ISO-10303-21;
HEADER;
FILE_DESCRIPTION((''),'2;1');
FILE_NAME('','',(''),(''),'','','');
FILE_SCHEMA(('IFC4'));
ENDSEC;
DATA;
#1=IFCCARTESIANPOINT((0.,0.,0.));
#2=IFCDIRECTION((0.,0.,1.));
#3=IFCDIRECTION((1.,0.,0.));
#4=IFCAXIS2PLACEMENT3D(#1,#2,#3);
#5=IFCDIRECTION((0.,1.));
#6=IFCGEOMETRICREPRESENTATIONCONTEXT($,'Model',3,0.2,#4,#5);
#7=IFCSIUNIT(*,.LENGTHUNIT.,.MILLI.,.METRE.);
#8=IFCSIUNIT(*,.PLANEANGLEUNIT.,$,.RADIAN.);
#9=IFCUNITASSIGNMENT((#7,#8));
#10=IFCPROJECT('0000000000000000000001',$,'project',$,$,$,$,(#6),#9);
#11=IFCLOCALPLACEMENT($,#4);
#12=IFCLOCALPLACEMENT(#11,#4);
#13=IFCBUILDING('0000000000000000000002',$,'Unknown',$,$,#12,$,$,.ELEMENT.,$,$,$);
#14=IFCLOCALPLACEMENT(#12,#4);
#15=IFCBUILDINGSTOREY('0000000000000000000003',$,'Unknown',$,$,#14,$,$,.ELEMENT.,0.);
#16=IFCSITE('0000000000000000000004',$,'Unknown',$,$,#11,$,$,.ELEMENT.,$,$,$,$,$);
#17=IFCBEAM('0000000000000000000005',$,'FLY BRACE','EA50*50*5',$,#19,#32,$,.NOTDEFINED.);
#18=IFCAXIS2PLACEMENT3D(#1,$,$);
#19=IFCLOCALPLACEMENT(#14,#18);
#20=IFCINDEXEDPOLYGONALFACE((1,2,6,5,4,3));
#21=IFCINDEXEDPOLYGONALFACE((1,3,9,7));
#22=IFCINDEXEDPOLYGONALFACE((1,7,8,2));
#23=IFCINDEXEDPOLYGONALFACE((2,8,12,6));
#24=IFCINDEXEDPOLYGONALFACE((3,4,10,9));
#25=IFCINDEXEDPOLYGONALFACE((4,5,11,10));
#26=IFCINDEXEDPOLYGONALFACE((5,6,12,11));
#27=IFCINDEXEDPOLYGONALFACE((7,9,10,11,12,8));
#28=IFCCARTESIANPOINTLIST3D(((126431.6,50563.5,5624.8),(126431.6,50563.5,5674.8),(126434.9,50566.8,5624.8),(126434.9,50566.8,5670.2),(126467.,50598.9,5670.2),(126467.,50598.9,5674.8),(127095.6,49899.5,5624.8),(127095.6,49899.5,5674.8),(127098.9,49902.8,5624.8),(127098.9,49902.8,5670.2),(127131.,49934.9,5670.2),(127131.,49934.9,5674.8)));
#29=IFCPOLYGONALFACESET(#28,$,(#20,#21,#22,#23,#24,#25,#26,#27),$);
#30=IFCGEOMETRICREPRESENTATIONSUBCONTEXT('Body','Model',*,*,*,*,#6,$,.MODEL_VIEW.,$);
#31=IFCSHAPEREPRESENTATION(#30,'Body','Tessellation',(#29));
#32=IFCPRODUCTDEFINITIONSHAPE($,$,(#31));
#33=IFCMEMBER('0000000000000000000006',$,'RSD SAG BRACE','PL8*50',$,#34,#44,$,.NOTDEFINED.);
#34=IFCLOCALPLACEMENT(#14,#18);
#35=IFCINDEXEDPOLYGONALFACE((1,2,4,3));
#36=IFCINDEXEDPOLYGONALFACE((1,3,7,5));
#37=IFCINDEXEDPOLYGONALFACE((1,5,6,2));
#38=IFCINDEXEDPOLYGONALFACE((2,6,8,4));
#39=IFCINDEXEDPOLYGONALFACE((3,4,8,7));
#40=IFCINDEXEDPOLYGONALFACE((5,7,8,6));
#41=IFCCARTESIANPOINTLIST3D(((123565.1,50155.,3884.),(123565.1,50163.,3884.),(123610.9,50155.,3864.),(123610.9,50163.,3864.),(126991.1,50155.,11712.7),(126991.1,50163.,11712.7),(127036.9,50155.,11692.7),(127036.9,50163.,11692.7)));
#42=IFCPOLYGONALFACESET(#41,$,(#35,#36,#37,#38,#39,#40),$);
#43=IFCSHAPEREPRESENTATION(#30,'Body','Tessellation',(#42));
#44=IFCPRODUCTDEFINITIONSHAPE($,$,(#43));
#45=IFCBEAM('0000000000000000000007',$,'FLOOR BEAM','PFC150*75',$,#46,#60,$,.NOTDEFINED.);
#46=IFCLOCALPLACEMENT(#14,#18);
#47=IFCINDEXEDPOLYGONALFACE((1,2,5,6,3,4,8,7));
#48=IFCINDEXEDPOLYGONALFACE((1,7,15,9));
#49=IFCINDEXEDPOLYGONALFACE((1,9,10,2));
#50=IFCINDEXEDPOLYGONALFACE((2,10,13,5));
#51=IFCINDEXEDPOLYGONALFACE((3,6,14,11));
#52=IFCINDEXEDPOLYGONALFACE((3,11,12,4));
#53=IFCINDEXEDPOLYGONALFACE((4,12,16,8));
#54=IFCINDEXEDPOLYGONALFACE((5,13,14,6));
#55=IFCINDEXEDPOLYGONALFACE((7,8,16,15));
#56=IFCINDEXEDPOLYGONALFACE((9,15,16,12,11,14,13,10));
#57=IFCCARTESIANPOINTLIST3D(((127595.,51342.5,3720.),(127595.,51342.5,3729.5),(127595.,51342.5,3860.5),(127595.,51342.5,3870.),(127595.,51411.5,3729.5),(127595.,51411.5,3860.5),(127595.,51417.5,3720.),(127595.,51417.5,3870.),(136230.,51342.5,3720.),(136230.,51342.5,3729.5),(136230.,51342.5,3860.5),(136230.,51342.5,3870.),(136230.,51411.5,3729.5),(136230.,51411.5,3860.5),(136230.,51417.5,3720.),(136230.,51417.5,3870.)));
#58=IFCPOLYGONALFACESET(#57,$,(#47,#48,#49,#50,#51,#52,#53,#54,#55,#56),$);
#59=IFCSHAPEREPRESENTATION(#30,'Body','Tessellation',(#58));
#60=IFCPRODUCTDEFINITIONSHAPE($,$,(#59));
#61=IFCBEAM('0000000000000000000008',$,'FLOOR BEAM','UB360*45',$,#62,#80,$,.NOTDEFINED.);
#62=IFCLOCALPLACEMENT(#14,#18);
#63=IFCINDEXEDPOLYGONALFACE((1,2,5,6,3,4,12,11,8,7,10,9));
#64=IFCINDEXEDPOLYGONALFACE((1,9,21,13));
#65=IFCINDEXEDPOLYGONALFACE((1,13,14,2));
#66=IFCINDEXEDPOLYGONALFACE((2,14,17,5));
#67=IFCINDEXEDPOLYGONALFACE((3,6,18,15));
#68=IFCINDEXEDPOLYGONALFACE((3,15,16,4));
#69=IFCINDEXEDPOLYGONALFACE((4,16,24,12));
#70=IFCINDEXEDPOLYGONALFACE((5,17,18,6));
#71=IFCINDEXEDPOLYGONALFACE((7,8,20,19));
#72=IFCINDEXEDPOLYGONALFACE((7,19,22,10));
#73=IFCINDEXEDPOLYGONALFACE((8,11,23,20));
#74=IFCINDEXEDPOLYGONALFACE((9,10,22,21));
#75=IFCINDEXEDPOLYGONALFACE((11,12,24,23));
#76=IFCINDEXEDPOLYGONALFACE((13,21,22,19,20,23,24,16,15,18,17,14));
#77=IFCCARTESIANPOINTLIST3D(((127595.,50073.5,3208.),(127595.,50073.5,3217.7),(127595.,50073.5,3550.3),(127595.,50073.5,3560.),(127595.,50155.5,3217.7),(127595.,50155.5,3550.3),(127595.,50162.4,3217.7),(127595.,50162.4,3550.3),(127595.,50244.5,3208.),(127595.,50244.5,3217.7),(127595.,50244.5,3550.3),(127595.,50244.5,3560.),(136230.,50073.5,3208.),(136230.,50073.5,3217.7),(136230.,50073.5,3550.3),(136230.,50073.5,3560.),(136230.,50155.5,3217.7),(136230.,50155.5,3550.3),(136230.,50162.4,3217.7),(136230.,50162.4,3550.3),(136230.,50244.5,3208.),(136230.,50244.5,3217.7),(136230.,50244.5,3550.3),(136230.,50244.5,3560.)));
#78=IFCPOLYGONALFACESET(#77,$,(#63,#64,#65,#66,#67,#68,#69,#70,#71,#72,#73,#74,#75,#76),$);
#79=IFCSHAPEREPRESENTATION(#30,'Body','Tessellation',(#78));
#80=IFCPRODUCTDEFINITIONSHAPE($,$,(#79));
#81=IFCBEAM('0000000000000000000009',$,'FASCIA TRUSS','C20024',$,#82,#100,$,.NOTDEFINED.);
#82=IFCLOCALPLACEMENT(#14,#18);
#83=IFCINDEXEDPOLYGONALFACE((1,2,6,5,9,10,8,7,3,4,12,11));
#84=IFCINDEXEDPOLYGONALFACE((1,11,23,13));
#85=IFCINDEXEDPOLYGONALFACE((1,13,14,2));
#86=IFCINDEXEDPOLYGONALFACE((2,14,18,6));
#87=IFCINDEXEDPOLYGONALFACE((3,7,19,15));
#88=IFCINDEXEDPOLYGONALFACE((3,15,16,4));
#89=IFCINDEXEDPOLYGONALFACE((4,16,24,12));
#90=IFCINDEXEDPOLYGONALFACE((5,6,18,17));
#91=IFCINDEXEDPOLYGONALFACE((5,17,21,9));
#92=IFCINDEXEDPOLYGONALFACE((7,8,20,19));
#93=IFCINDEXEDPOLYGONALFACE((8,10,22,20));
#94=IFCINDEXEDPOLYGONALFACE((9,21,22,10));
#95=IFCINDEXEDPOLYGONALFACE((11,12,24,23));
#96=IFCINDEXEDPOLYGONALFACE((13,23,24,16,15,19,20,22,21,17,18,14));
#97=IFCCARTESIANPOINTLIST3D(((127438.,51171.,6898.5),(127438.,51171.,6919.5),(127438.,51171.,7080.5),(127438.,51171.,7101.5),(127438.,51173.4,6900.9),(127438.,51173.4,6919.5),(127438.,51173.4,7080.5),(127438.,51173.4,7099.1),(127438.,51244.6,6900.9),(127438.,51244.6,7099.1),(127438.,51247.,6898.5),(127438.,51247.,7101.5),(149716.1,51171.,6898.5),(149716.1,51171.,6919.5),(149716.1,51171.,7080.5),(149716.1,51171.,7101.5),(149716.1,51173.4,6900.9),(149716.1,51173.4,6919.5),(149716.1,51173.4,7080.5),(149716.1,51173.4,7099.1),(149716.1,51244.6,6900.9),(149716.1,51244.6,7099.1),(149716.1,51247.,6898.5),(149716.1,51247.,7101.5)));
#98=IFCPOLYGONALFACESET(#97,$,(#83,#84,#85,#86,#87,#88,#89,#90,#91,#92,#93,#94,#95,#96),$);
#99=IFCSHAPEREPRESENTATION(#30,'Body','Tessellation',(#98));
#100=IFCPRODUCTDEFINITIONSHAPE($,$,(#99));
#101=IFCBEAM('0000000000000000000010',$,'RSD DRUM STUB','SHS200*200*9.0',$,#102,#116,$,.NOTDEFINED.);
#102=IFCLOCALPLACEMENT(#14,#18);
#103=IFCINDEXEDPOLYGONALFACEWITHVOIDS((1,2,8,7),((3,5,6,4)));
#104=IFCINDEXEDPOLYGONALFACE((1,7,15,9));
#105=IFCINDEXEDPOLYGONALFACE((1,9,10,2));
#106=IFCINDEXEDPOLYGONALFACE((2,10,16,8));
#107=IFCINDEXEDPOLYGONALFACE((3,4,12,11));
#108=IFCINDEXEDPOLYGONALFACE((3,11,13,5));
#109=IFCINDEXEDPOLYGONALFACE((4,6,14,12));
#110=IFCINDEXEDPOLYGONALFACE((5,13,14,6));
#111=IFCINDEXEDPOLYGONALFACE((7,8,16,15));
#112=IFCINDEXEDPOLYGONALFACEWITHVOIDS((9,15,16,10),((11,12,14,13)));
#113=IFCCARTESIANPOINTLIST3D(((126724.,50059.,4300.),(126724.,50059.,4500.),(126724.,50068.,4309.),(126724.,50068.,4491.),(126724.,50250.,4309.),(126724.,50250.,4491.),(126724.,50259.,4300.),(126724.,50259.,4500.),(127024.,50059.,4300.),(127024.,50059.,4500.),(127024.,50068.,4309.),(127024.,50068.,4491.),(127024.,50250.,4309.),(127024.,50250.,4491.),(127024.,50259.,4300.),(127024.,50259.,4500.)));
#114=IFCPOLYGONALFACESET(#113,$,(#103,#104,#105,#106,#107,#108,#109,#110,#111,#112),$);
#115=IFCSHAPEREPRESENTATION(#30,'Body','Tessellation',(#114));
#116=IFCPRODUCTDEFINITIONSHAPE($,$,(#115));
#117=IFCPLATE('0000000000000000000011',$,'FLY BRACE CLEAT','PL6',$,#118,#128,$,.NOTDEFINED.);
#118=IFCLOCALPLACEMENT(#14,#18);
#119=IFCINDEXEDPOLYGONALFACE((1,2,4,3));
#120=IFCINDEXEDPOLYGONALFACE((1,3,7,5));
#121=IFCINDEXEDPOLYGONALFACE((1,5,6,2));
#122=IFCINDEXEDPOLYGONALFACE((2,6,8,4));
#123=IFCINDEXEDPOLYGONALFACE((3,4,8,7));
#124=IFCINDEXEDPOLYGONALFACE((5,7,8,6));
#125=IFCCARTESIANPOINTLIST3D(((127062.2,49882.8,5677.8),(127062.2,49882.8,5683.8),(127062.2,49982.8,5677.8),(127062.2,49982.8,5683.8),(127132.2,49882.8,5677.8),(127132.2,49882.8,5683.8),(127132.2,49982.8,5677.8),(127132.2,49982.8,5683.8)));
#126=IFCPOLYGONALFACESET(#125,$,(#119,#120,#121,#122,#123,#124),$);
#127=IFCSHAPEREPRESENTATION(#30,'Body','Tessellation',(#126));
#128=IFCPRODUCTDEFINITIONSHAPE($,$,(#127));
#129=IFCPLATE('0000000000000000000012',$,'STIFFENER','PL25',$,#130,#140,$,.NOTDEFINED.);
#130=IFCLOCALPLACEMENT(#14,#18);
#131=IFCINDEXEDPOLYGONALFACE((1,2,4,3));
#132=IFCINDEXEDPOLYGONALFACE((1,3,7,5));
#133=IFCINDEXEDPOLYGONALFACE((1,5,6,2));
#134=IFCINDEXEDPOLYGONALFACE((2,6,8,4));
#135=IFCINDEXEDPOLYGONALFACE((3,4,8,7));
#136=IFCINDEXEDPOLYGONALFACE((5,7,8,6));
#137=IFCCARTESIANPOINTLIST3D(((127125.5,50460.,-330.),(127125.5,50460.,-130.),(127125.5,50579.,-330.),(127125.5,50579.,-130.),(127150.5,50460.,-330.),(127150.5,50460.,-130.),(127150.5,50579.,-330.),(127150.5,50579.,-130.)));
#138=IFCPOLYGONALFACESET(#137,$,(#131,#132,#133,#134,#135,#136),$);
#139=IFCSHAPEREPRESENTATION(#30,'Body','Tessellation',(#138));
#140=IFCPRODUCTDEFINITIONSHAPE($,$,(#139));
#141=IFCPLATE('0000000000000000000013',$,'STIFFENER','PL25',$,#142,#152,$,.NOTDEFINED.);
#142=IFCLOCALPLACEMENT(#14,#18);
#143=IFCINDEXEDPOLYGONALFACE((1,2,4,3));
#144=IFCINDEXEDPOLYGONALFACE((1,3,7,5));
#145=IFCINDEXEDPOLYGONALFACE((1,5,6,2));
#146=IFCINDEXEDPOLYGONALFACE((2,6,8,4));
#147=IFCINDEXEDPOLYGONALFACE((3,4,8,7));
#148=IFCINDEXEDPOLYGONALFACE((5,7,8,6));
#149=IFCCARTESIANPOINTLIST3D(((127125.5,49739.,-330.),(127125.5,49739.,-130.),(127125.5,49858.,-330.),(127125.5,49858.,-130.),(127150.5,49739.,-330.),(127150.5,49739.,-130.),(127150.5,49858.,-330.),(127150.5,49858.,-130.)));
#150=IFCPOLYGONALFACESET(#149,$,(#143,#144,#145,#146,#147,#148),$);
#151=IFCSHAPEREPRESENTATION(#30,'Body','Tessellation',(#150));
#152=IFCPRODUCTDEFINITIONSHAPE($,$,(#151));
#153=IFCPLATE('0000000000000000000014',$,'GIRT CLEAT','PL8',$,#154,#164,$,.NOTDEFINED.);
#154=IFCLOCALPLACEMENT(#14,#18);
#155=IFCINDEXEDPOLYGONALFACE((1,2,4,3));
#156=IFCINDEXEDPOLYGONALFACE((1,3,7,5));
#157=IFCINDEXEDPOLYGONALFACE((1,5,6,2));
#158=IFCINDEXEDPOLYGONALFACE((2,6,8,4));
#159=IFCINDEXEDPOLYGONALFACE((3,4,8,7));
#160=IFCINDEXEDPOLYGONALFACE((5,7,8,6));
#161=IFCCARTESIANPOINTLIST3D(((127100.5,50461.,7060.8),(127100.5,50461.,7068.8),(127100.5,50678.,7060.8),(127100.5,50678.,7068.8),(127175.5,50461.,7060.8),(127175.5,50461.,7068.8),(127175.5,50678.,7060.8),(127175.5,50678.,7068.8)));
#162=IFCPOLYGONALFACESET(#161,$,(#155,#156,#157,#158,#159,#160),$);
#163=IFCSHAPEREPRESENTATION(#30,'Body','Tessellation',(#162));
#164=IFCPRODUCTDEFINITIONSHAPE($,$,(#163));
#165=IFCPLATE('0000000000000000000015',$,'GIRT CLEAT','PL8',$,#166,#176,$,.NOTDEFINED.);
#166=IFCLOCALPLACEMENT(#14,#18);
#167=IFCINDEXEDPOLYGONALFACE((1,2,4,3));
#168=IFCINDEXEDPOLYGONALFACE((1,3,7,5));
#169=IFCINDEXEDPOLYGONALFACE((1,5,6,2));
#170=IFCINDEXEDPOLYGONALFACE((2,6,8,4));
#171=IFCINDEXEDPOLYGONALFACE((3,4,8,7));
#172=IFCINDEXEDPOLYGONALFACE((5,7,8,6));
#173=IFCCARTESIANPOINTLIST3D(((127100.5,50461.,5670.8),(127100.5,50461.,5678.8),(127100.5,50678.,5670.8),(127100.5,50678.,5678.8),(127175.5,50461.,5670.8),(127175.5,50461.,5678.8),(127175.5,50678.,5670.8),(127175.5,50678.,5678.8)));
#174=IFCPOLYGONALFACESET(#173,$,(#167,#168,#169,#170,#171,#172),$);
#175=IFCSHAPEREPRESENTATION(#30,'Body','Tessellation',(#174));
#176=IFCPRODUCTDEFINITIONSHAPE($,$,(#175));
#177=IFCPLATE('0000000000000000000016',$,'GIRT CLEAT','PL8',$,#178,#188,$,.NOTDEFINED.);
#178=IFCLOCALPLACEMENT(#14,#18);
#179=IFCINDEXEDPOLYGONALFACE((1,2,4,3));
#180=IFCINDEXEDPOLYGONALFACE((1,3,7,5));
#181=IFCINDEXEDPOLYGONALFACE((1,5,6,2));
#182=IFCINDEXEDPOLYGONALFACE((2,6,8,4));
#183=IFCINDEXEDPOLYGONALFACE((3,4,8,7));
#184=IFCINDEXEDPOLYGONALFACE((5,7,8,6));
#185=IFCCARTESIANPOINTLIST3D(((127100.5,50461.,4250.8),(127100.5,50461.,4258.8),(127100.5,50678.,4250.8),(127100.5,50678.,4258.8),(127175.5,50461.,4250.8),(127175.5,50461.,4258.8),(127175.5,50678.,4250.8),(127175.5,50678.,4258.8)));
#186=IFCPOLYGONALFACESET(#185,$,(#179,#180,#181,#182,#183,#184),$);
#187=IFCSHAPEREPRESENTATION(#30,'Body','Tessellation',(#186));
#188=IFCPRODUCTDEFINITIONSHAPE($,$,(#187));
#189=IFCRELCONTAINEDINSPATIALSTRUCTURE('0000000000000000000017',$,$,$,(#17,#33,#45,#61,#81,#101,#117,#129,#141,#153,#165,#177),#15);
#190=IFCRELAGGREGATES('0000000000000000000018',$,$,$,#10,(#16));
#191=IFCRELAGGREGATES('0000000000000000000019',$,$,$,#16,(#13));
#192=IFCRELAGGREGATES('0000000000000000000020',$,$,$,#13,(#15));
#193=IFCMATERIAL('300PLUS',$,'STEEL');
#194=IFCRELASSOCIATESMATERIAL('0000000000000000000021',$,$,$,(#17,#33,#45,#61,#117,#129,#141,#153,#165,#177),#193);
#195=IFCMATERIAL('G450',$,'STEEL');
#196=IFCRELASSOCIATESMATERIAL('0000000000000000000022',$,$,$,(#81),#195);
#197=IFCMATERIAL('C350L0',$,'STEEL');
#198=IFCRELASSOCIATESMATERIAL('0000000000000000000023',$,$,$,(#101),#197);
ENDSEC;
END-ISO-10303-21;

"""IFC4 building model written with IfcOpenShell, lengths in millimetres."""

from ifc_helpers import new_model, si_unit, direction, frame, origin_with_axes, place, context, subcontext, project, spatial, line, indexed_curve, outline, extrude, material, element, save


model = new_model("IFC4")

# Units and contexts
model_context = context("Model", 3, precision=0.2, world=origin_with_axes(), true_north=direction((0.0, 1.0)))
body_context = subcontext(model_context, "Body", "Model", "MODEL_VIEW")
ifc_project = project(units=[si_unit("LENGTHUNIT", "METRE", prefix="MILLI"), si_unit("PLANEANGLEUNIT", "RADIAN")], contexts=[model_context])

# Site, building, storey
site_placement = place(None, origin_with_axes())
site = spatial("IfcSite", under=ifc_project, at=site_placement, Name="Unknown", CompositionType="ELEMENT")
building_placement = place(site_placement, origin_with_axes())
building = spatial("IfcBuilding", under=site, at=building_placement, Name="Unknown", CompositionType="ELEMENT")
storey_placement = place(building_placement, origin_with_axes())
storey = spatial("IfcBuildingStorey", under=building, at=storey_placement, Name="Unknown", CompositionType="ELEMENT", Elevation=0.0)

# Shared definitions
ifc_material_1 = material(Name="G450", Category="STEEL")
ifc_material_2 = material(Name="300PLUS", Category="STEEL")
ifc_material_3 = material(Name="C350L0", Category="STEEL")

# Beam
beam_1_placement = place(storey_placement, frame((127113.3, 49917.2, 5649.8), z_axis=(0.0, 0.0, -1.0), x_axis=(-0.707107, 0.707107, 0.0)))
element("IfcBeam", 1, at=beam_1_placement, inside=storey, material=ifc_material_2, Name="FLY BRACE", Description="EA50*50*5", PredefinedType="NOTDEFINED", context=body_context, shape_type="SolidModel", body=[
    extrude(outline(indexed_curve([(-25.0, -25.0), (25.0, -25.0), (25.0, -20.4), (-20.4, -20.4), (-20.4, 25.0), (-25.0, 25.0)], segments=[line(1, 2, 3, 4, 5, 6, 1)])), frame((0.0, 0.0, 0.0), z_axis=(-1.0, 0.0, 0.0), x_axis=(0.0, 0.0, 1.0)), (0.0, 0.0, -1.0), 939.0),
])

# Member
member_placement = place(storey_placement, frame((123588.0, 50159.0, 3874.0), z_axis=(0.0, -1.0, 0.0), x_axis=(0.400912, 0.0, 0.916117)))
element("IfcMember", 2, at=member_placement, inside=storey, material=ifc_material_2, Name="RSD SAG BRACE", Description="PL8*50", PredefinedType="NOTDEFINED", context=body_context, shape_type="SolidModel", body=[
    extrude(outline(indexed_curve([(-4.0, -25.0), (4.0, -25.0), (4.0, 25.0), (-4.0, 25.0)], segments=[line(1, 2, 3, 4, 1)])), frame((0.0, 0.0, 0.0), z_axis=(-1.0, 0.0, 0.0), x_axis=(0.0, 0.0, 1.0)), (0.0, 0.0, -1.0), 8545.5),
])

# Beams
beam_2_placement = place(storey_placement, frame((127595.0, 51380.0, 3795.0), z_axis=(0.0, -1.0, 0.0), x_axis=(1.0, 0.0, 0.0)))
element("IfcBeam", 3, at=beam_2_placement, inside=storey, material=ifc_material_2, Name="FLOOR BEAM", Description="PFC150*75", PredefinedType="NOTDEFINED", context=body_context, shape_type="SolidModel", body=[
    extrude(outline(indexed_curve([(-37.5, -75.0), (37.5, -75.0), (37.5, -65.5), (-31.5, -65.5), (-31.5, 65.5), (37.5, 65.5), (37.5, 75.0), (-37.5, 75.0)], segments=[line(1, 2, 3, 4, 5, 6, 7, 8, 1)])), frame((0.0, 0.0, 0.0), z_axis=(-1.0, 0.0, 0.0), x_axis=(0.0, 0.0, 1.0)), (0.0, 0.0, -1.0), 8635.0),
])
beam_3_placement = place(storey_placement, frame((127595.0, 50159.0, 3384.0), z_axis=(0.0, -1.0, 0.0), x_axis=(1.0, 0.0, 0.0)))
element("IfcBeam", 4, at=beam_3_placement, inside=storey, material=ifc_material_2, Name="FLOOR BEAM", Description="UB360*45", PredefinedType="NOTDEFINED", context=body_context, shape_type="SolidModel", body=[
    extrude(outline(indexed_curve([(-85.5, -176.0), (85.5, -176.0), (85.5, -166.3), (3.5, -166.3), (3.5, 166.3), (85.5, 166.3), (85.5, 176.0), (-85.5, 176.0), (-85.5, 166.3), (-3.5, 166.3), (-3.5, -166.3), (-85.5, -166.3)], segments=[line(1, 2, 3, 4, 5, 6, 7, 8, 9, 10, 11, 12, 1)])), frame((0.0, 0.0, 0.0), z_axis=(-1.0, 0.0, 0.0), x_axis=(0.0, 0.0, 1.0)), (0.0, 0.0, -1.0), 8635.0),
])
beam_4_placement = place(storey_placement, frame((127438.0, 51209.0, 7000.0), z_axis=(0.0, -1.0, 0.0), x_axis=(1.0, 0.0, 0.0)))
element("IfcBeam", 5, at=beam_4_placement, inside=storey, material=ifc_material_1, Name="FASCIA TRUSS", Description="C20024", PredefinedType="NOTDEFINED", context=body_context, shape_type="SolidModel", body=[
    extrude(outline(indexed_curve([(38.0, -101.5), (38.0, -80.5), (35.6, -80.5), (35.6, -99.1), (-35.6, -99.1), (-35.6, 99.1), (35.6, 99.1), (35.6, 80.5), (38.0, 80.5), (38.0, 101.5), (-38.0, 101.5), (-38.0, -101.5)], segments=[line(1, 2, 3, 4, 5, 6, 7, 8, 9, 10, 11, 12, 1)])), frame((0.0, 0.0, 0.0), z_axis=(-1.0, 0.0, 0.0), x_axis=(0.0, 0.0, 1.0)), (0.0, 0.0, -1.0), 22278.1),
])
beam_5_placement = place(storey_placement, frame((127024.0, 50159.0, 4400.0), z_axis=(0.0, 0.0, 1.0), x_axis=(-1.0, 0.0, 0.0)))
element("IfcBeam", 6, at=beam_5_placement, inside=storey, material=ifc_material_3, Name="RSD DRUM STUB", Description="SHS200*200*9.0", PredefinedType="NOTDEFINED", context=body_context, shape_type="SolidModel", body=[
    extrude(outline(indexed_curve([(-100.0, -100.0), (100.0, -100.0), (100.0, 100.0), (-100.0, 100.0)], segments=[line(1, 2, 3, 4, 1)]), holes=[indexed_curve([(-91.0, -91.0), (-91.0, 91.0), (91.0, 91.0), (91.0, -91.0)], segments=[line(1, 2, 3, 4, 1)])]), frame((0.0, 0.0, 0.0), z_axis=(-1.0, 0.0, 0.0), x_axis=(0.0, 0.0, 1.0)), (0.0, 0.0, -1.0), 300.0),
])

# Plates
plate_1_placement = place(storey_placement, frame((127132.2, 49982.8, 5680.8), z_axis=(0.0, 0.0, 1.0), x_axis=(-1.0, 0.0, 0.0)))
element("IfcPlate", 7, at=plate_1_placement, inside=storey, material=ifc_material_2, Name="FLY BRACE CLEAT", Description="PL6", PredefinedType="NOTDEFINED", context=body_context, shape_type="SolidModel", body=[
    extrude(outline(indexed_curve([(0.0, 0.0), (70.0, 0.0), (70.0, 100.0), (0.0, 100.0)], segments=[line(1, 2, 3, 4, 1)])), frame((0.0, 0.0, 3.0), z_axis=(0.0, 0.0, 1.0), x_axis=(1.0, 0.0, 0.0)), (0.0, 0.0, -1.0), 6.0),
])
for number, where, z_axis, x_axis, name in (
    (8, (127138.0, 50460.0, -330.0), (1.0, 0.0, 0.0), (0.0, 1.0, 0.0), "STIFFENER"),
    (9, (127138.0, 49858.0, -130.0), (1.0, 0.0, 0.0), (0.0, -1.0, 0.0), "STIFFENER"),
):
    element("IfcPlate", number, at=place(storey_placement, frame(where, z_axis=z_axis, x_axis=x_axis)), inside=storey, material=ifc_material_2, Name=name, Description="PL25", PredefinedType="NOTDEFINED", context=body_context, shape_type="SolidModel", body=[
        extrude(outline(indexed_curve([(0.0, 0.0), (119.0, 0.0), (119.0, 200.0), (0.0, 200.0)], segments=[line(1, 2, 3, 4, 1)])), frame((0.0, 0.0, 12.5), z_axis=(0.0, 0.0, 1.0), x_axis=(1.0, 0.0, 0.0)), (0.0, 0.0, -1.0), 25.0),
    ])
for number, where, z_axis, x_axis, name in (
    (10, (127100.5, 50461.0, 7064.8), (0.0, 0.0, 1.0), (1.0, 0.0, 0.0), "GIRT CLEAT"),
    (11, (127100.5, 50461.0, 5674.8), (0.0, 0.0, 1.0), (1.0, 0.0, 0.0), "GIRT CLEAT"),
    (12, (127100.5, 50461.0, 4254.8), (0.0, 0.0, 1.0), (1.0, 0.0, 0.0), "GIRT CLEAT"),
):
    element("IfcPlate", number, at=place(storey_placement, frame(where, z_axis=z_axis, x_axis=x_axis)), inside=storey, material=ifc_material_2, Name=name, Description="PL8", PredefinedType="NOTDEFINED", context=body_context, shape_type="SolidModel", body=[
        extrude(outline(indexed_curve([(0.0, 0.0), (75.0, 0.0), (75.0, 217.0), (0.0, 217.0)], segments=[line(1, 2, 3, 4, 1)])), frame((0.0, 0.0, 4.0), z_axis=(0.0, 0.0, 1.0), x_axis=(1.0, 0.0, 0.0)), (0.0, 0.0, -1.0), 8.0),
    ])

save(model, "model.ifc")
